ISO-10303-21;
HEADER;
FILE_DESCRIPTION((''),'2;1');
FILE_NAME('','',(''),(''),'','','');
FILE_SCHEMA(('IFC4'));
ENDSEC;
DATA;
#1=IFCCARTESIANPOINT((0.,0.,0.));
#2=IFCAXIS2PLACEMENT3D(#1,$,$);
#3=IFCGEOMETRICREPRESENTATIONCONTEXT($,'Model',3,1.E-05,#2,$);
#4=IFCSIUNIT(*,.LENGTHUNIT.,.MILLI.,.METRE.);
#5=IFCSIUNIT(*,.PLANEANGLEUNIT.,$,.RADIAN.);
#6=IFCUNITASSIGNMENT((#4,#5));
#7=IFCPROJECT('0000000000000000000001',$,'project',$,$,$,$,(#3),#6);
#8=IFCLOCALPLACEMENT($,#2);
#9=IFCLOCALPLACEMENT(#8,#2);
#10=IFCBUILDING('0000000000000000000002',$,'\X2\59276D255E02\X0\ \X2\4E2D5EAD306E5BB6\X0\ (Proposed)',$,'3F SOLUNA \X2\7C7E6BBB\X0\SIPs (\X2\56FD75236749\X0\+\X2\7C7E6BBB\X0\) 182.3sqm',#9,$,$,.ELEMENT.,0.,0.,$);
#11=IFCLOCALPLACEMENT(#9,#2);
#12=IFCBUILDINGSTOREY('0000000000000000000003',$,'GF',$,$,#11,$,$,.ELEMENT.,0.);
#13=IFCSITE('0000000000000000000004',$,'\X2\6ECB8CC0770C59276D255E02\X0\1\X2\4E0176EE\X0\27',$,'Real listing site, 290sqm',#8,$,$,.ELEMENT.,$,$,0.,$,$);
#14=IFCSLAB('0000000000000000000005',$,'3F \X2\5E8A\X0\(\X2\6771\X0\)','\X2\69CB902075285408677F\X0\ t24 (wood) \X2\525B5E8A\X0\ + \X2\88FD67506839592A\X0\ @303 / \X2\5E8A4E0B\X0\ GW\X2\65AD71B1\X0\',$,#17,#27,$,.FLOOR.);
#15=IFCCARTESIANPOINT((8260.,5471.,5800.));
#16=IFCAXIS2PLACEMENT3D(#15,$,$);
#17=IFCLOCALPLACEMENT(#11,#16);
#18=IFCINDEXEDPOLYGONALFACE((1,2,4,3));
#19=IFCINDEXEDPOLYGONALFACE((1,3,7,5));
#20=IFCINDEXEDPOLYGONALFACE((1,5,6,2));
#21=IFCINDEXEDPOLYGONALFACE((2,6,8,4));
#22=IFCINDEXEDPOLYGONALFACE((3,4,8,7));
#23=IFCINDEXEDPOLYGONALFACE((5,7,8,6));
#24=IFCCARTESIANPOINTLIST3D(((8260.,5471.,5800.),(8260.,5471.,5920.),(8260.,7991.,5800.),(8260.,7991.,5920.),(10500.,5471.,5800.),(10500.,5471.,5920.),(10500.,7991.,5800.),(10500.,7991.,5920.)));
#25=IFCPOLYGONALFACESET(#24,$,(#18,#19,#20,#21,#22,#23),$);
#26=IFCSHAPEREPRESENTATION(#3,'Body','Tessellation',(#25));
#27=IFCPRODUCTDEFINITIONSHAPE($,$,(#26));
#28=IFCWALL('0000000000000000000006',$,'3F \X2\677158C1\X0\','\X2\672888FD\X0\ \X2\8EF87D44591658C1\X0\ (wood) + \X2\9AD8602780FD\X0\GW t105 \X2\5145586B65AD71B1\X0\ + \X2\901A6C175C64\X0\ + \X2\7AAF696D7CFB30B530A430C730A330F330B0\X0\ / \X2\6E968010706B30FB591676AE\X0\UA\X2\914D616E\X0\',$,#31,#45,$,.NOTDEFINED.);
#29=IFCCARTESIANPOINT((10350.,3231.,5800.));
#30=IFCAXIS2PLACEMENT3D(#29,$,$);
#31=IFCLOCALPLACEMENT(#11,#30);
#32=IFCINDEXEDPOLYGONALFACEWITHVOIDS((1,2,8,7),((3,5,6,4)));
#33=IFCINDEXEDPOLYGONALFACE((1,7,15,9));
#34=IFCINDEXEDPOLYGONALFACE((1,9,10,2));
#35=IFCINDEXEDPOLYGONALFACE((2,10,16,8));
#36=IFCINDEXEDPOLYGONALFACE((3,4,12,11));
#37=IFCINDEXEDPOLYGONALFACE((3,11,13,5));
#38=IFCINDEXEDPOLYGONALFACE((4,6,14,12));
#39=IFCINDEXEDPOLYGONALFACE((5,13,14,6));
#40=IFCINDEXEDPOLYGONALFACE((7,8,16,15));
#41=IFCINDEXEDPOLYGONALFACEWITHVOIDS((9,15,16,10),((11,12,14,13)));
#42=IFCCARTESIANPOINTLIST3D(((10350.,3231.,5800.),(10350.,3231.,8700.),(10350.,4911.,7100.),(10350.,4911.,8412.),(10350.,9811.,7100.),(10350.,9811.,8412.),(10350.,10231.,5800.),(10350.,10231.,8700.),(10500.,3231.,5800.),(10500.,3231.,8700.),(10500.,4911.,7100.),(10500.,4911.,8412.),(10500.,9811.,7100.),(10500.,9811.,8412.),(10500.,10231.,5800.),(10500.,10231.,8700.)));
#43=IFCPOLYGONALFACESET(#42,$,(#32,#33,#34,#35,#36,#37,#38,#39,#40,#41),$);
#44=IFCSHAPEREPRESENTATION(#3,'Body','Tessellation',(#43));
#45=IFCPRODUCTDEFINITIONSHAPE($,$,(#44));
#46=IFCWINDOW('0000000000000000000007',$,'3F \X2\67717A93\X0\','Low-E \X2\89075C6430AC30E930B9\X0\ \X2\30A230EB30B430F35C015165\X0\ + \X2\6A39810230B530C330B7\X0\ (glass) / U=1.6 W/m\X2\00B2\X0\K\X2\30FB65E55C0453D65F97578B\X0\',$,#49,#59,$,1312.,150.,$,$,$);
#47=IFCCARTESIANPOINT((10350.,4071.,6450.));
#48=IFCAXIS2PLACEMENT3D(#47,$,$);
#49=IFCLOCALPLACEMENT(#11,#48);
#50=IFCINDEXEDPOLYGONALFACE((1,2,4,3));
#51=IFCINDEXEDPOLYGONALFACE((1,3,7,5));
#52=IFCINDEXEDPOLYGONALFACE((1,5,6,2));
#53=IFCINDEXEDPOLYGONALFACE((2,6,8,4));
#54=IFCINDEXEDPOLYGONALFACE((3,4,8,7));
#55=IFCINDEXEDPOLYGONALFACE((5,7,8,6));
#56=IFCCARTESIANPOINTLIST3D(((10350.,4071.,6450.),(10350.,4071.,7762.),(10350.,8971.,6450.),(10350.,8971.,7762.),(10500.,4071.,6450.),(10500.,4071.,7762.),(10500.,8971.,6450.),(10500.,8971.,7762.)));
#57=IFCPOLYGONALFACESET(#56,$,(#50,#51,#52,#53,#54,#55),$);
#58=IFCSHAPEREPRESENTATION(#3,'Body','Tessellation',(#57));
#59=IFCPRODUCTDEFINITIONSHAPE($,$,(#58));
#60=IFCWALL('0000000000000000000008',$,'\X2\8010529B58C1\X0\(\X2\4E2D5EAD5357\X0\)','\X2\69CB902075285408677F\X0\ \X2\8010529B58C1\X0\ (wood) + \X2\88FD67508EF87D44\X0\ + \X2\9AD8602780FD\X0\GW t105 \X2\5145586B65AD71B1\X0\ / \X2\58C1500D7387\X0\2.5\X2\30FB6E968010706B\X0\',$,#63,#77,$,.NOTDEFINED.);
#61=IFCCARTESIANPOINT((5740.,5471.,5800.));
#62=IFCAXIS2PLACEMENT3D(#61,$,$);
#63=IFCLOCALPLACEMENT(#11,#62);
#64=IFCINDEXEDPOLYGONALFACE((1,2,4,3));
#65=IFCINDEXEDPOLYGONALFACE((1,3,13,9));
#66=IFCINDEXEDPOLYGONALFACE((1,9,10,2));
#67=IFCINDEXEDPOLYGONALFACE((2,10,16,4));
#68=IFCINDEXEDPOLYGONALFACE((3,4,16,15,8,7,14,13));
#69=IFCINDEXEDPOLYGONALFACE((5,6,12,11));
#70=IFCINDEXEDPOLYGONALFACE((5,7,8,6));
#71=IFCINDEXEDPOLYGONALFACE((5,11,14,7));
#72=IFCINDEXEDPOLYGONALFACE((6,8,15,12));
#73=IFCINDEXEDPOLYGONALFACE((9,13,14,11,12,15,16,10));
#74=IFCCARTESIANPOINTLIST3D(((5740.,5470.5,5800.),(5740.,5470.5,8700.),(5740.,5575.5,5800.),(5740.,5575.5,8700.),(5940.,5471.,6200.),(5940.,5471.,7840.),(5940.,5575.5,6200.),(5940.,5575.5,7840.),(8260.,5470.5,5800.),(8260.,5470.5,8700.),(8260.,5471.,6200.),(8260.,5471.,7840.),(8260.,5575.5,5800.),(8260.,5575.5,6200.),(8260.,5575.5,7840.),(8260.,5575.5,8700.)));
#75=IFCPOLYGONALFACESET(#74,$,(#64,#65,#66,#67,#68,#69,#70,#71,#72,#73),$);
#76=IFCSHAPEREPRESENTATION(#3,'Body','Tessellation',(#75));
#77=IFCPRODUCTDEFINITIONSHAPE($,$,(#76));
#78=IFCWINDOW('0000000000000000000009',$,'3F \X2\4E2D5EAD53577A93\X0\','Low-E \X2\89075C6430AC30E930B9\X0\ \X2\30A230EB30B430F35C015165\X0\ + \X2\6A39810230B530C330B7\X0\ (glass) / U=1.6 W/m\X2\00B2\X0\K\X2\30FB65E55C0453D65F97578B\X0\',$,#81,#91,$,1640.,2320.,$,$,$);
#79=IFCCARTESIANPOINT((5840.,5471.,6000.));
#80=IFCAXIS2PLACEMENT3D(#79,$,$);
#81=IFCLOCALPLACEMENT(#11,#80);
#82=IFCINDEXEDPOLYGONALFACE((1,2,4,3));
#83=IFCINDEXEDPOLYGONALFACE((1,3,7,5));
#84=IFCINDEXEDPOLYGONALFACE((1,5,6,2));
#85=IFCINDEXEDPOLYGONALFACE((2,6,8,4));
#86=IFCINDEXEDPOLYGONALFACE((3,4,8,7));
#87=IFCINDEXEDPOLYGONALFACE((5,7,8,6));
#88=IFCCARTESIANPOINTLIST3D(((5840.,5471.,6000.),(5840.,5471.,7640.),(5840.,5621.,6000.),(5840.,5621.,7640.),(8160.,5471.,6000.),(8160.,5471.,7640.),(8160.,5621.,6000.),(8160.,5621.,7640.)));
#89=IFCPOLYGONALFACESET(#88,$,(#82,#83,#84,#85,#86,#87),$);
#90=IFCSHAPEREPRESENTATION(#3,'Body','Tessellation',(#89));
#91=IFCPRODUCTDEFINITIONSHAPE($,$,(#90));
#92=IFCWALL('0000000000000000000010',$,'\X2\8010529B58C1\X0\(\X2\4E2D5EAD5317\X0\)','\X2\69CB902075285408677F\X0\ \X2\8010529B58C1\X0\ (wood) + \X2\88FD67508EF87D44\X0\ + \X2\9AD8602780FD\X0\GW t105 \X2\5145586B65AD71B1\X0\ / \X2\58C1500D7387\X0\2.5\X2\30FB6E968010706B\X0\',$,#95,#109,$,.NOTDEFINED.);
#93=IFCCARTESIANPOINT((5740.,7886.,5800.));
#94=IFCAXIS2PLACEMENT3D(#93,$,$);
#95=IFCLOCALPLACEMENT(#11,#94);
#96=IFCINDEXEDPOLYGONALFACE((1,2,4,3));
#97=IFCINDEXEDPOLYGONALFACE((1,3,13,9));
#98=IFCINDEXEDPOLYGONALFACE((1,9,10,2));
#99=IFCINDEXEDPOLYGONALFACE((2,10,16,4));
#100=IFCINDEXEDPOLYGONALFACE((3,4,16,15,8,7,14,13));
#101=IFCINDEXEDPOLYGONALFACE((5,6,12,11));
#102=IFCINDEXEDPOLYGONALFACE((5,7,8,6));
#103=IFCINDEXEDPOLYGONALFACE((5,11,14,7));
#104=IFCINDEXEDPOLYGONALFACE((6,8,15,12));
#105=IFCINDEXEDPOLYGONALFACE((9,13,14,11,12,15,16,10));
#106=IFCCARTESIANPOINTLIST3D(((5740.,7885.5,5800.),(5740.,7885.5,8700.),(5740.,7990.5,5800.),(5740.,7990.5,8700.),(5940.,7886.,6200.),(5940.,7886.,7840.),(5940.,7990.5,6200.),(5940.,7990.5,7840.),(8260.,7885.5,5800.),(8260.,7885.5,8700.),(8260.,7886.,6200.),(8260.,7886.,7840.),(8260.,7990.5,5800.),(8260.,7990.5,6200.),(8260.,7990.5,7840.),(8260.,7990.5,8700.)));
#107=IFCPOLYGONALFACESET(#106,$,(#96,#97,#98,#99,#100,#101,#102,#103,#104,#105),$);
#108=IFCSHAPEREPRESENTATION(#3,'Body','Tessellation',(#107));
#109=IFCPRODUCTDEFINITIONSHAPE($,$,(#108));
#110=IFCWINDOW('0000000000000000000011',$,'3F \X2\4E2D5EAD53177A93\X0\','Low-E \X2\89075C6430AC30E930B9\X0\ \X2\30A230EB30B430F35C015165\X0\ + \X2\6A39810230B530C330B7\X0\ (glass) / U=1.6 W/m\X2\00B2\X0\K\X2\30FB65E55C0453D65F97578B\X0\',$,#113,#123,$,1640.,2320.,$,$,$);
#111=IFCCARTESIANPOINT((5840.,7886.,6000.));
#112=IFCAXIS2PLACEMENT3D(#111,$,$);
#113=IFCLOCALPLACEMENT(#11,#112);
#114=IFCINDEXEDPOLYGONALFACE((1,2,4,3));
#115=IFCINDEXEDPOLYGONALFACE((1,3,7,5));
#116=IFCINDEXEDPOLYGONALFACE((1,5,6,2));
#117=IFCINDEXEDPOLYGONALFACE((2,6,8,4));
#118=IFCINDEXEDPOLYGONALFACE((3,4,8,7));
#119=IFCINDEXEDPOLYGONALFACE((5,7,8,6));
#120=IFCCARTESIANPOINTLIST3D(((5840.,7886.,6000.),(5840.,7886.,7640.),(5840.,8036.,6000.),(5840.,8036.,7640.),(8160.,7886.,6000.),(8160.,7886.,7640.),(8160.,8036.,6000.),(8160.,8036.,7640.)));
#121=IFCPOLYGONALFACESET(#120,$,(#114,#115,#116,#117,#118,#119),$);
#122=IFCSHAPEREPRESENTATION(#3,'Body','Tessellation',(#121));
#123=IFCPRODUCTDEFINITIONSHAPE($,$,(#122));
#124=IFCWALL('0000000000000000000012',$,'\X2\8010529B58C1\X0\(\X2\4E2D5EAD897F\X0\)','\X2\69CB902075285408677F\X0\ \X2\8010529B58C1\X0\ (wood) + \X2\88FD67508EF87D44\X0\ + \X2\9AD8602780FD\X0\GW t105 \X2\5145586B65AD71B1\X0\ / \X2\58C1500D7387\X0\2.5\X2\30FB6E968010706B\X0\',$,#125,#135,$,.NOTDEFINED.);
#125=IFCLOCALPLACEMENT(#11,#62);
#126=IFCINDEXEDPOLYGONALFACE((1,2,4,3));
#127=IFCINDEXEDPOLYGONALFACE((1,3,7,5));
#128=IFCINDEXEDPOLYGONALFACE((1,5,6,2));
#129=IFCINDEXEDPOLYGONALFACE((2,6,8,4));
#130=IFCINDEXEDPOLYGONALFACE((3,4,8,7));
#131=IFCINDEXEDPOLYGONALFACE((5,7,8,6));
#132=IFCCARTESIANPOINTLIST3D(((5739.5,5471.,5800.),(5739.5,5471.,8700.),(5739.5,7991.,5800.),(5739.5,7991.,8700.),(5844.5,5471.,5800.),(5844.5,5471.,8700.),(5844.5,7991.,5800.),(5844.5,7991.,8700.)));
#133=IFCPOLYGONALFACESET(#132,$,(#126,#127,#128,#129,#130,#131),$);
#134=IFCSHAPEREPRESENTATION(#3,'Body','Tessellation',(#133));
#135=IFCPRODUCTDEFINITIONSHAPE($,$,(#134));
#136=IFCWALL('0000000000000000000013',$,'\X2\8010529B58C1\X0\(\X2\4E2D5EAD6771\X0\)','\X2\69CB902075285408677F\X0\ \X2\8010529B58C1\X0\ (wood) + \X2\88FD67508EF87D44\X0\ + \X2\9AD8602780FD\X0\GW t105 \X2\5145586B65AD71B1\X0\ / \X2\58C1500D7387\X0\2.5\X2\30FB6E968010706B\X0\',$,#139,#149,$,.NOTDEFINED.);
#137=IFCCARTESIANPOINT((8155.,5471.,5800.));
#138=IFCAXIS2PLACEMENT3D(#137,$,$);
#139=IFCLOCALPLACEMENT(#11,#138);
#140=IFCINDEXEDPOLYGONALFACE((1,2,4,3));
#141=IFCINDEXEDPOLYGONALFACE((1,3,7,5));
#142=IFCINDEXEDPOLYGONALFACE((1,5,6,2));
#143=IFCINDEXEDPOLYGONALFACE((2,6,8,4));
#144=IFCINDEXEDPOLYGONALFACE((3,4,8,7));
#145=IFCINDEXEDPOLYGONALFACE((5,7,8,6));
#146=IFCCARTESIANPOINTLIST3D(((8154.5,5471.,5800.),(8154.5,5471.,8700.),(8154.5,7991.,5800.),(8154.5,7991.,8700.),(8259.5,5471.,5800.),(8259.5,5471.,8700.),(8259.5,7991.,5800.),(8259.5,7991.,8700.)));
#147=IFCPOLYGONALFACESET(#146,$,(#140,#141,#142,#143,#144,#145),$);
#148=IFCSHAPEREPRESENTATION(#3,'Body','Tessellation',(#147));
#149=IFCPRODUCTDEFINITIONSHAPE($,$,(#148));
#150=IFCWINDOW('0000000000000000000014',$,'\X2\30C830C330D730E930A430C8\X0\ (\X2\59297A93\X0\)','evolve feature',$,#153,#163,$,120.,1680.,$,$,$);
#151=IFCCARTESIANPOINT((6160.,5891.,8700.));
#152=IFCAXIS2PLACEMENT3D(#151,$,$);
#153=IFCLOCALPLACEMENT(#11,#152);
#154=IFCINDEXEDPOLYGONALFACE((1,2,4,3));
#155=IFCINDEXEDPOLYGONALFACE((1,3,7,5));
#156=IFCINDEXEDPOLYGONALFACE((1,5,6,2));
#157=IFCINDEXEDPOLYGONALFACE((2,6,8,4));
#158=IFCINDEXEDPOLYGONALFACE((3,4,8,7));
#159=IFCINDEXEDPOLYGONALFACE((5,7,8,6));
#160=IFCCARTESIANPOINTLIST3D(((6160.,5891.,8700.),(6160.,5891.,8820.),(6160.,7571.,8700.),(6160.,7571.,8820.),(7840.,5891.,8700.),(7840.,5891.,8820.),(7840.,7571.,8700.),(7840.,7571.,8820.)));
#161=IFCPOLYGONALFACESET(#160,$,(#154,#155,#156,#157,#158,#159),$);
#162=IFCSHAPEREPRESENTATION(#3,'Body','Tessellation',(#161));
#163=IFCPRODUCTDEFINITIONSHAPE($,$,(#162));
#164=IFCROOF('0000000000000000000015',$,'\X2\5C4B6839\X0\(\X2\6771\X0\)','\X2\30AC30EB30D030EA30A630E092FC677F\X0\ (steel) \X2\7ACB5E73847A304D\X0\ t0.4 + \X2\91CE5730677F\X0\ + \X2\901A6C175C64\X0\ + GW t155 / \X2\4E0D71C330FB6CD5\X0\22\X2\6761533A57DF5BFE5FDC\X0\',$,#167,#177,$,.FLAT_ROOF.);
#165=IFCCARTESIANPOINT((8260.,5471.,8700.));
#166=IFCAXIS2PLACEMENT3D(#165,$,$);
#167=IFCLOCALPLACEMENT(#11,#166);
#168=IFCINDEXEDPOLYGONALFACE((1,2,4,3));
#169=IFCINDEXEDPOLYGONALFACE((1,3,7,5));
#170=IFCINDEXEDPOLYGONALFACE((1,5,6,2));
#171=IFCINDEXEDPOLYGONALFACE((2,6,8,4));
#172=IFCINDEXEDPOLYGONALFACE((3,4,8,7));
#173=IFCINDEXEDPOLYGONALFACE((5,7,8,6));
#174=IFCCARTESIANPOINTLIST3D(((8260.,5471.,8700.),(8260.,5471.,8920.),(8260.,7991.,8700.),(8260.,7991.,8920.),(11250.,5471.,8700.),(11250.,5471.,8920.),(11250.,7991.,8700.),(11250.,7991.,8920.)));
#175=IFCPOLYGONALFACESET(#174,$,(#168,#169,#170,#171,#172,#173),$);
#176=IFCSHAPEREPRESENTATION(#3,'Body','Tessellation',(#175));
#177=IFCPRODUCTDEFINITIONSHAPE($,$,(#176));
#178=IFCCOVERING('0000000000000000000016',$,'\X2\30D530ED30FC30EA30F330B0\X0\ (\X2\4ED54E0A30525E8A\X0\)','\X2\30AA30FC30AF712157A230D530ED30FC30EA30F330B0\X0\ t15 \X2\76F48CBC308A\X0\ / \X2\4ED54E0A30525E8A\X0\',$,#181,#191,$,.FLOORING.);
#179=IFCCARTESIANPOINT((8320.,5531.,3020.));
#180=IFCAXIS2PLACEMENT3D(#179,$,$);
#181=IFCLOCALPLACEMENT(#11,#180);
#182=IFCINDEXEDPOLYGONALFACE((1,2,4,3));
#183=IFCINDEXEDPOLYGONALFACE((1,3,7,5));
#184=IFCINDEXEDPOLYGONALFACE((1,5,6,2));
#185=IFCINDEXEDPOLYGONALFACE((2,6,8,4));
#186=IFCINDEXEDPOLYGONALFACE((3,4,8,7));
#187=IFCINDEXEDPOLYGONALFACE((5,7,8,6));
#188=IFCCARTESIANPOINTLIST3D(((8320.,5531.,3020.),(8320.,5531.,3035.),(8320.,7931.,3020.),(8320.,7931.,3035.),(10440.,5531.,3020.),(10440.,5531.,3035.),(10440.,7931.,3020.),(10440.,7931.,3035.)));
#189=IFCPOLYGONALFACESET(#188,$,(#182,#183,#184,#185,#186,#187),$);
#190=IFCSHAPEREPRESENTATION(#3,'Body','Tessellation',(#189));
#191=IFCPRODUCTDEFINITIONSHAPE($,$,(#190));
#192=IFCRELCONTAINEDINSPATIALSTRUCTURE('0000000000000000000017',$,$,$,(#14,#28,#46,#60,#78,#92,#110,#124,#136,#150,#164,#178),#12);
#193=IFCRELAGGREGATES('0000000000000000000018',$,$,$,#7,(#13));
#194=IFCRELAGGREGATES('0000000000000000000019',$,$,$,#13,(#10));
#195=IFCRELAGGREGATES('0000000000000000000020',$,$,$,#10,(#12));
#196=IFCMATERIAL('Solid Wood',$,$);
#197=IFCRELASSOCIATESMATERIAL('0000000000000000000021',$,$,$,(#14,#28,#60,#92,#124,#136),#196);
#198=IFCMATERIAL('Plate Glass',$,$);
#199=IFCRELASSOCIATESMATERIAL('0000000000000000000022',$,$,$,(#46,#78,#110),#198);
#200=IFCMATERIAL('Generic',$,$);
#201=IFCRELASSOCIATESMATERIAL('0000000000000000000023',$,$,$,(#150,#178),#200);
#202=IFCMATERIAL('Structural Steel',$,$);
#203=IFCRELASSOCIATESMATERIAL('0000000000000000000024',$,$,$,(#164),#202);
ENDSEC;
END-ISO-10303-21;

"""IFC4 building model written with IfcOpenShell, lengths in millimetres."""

from ifc_helpers import new_model, si_unit, frame, frame_2d, origin, place, context, project, spatial, rectangle, extrude, material, element, fill, save


model = new_model("IFC4")

# Units and contexts
model_context = context("Model", 3, precision=1e-05, world=origin())
ifc_project = project(units=[si_unit("LENGTHUNIT", "METRE", prefix="MILLI"), si_unit("PLANEANGLEUNIT", "RADIAN")], contexts=[model_context])

# Site, building, storey
site_placement = place(None, origin())
site = spatial("IfcSite", under=ifc_project, at=site_placement, Name="滋賀県大津市1丁目27", ObjectType="Real listing site, 290sqm", CompositionType="ELEMENT", RefElevation=0.0)
building_placement = place(site_placement, origin())
building = spatial("IfcBuilding", under=site, at=building_placement, Name="大津市 中庭の家 (Proposed)", ObjectType="3F SOLUNA 籾殻SIPs (国産杉+籾殻) 182.3sqm", CompositionType="ELEMENT", ElevationOfRefHeight=0.0, ElevationOfTerrain=0.0)
storey_placement = place(building_placement, origin())
storey = spatial("IfcBuildingStorey", under=building, at=storey_placement, Name="GF", CompositionType="ELEMENT", Elevation=0.0)

# Slab
ifc_material_1 = material(Name="Solid Wood")
slab_placement = place(storey_placement, frame((8260.0, 5471.0, 5800.0)))
element("IfcSlab", 1, at=slab_placement, inside=storey, material=ifc_material_1, Name="3F 床(東)", Description="構造用合板 t24 (wood) 剛床 + 製材根太 @303 / 床下 GW断熱", PredefinedType="FLOOR", context=model_context, shape_type="SweptSolid", body=[
    extrude(rectangle(XDim=2240.0, YDim=2520.0, at=frame_2d((1120.0, 1260.0))), frame((8260.0, 5471.0, 5800.0)), (0.0, 0.0, 1.0), 120.0),
])

# Walls, openings, windows
wall_1_placement = place(storey_placement, frame((10350.0, 3231.0, 5800.0)))
wall_1 = element("IfcWall", 2, at=wall_1_placement, inside=storey, material=ifc_material_1, Name="3F 東壁", Description="木製 軸組外壁 (wood) + 高性能GW t105 充填断熱 + 通気層 + 窯業系サイディング / 準耐火・外皮UA配慮", PredefinedType="NOTDEFINED", context=model_context, shape_type="SweptSolid", body=[
    extrude(rectangle(XDim=150.0, YDim=7000.0, at=frame_2d((75.0, 3500.0))), frame((10350.0, 3231.0, 5800.0)), (0.0, 0.0, 1.0), 2900.0),
])
opening_1_placement = place(storey_placement, frame((10350.0, 4071.0, 6450.0)))
opening_1 = element("IfcOpeningElement", 3, at=opening_1_placement, cuts=wall_1, PredefinedType="NOTDEFINED", context=model_context, shape_type="SweptSolid", body=[
    extrude(rectangle(XDim=150.0, YDim=4900.0, at=frame_2d((75.0, 2450.0))), frame((10350.0, 4071.0, 6450.0)), (0.0, 0.0, 1.0), 1312.0),
])
ifc_material_2 = material(Name="Plate Glass")
window_1_placement = place(storey_placement, frame((10350.0, 4071.0, 6450.0)))
window_1 = element("IfcWindow", 4, at=window_1_placement, inside=storey, material=ifc_material_2, Name="3F 東窓", Description="Low-E 複層ガラス アルゴン封入 + 樹脂サッシ (glass) / U=1.6 W/m²K・日射取得型", OverallHeight=1312.0, OverallWidth=150.0, context=model_context, shape_type="SweptSolid", body=[
    extrude(rectangle(XDim=150.0, YDim=4900.0, at=frame_2d((75.0, 2450.0))), frame((10350.0, 4071.0, 6450.0)), (0.0, 0.0, 1.0), 1312.0),
])
fill(opening_1, window_1)
wall_2_placement = place(storey_placement, frame((5740.0, 5471.0, 5800.0)))
wall_2 = element("IfcWall", 5, at=wall_2_placement, inside=storey, material=ifc_material_1, Name="耐力壁(中庭南)", Description="構造用合板 耐力壁 (wood) + 製材軸組 + 高性能GW t105 充填断熱 / 壁倍率2.5・準耐火", PredefinedType="NOTDEFINED", context=model_context, shape_type="SweptSolid", body=[
    extrude(rectangle(XDim=2520.0, YDim=105.0, at=frame_2d((1260.0, 52.0))), frame((5740.0, 5471.0, 5800.0)), (0.0, 0.0, 1.0), 2900.0),
])
opening_2_placement = place(storey_placement, frame((5840.0, 5471.0, 6000.0)))
opening_2 = element("IfcOpeningElement", 6, at=opening_2_placement, cuts=wall_2, PredefinedType="NOTDEFINED", context=model_context, shape_type="SweptSolid", body=[
    extrude(rectangle(XDim=2320.0, YDim=150.0, at=frame_2d((1160.0, 75.0))), frame((5840.0, 5471.0, 6000.0)), (0.0, 0.0, 1.0), 1640.0),
])
window_2_placement = place(storey_placement, frame((5840.0, 5471.0, 6000.0)))
window_2 = element("IfcWindow", 7, at=window_2_placement, inside=storey, material=ifc_material_2, Name="3F 中庭南窓", Description="Low-E 複層ガラス アルゴン封入 + 樹脂サッシ (glass) / U=1.6 W/m²K・日射取得型", OverallHeight=1640.0, OverallWidth=2320.0, context=model_context, shape_type="SweptSolid", body=[
    extrude(rectangle(XDim=2320.0, YDim=150.0, at=frame_2d((1160.0, 75.0))), frame((5840.0, 5471.0, 6000.0)), (0.0, 0.0, 1.0), 1640.0),
])
fill(opening_2, window_2)
wall_3_placement = place(storey_placement, frame((5740.0, 7886.0, 5800.0)))
wall_3 = element("IfcWall", 8, at=wall_3_placement, inside=storey, material=ifc_material_1, Name="耐力壁(中庭北)", Description="構造用合板 耐力壁 (wood) + 製材軸組 + 高性能GW t105 充填断熱 / 壁倍率2.5・準耐火", PredefinedType="NOTDEFINED", context=model_context, shape_type="SweptSolid", body=[
    extrude(rectangle(XDim=2520.0, YDim=105.0, at=frame_2d((1260.0, 52.0))), frame((5740.0, 7886.0, 5800.0)), (0.0, 0.0, 1.0), 2900.0),
])
opening_3_placement = place(storey_placement, frame((5840.0, 7886.0, 6000.0)))
opening_3 = element("IfcOpeningElement", 9, at=opening_3_placement, cuts=wall_3, PredefinedType="NOTDEFINED", context=model_context, shape_type="SweptSolid", body=[
    extrude(rectangle(XDim=2320.0, YDim=150.0, at=frame_2d((1160.0, 75.0))), frame((5840.0, 7886.0, 6000.0)), (0.0, 0.0, 1.0), 1640.0),
])
window_3_placement = place(storey_placement, frame((5840.0, 7886.0, 6000.0)))
window_3 = element("IfcWindow", 10, at=window_3_placement, inside=storey, material=ifc_material_2, Name="3F 中庭北窓", Description="Low-E 複層ガラス アルゴン封入 + 樹脂サッシ (glass) / U=1.6 W/m²K・日射取得型", OverallHeight=1640.0, OverallWidth=2320.0, context=model_context, shape_type="SweptSolid", body=[
    extrude(rectangle(XDim=2320.0, YDim=150.0, at=frame_2d((1160.0, 75.0))), frame((5840.0, 7886.0, 6000.0)), (0.0, 0.0, 1.0), 1640.0),
])
fill(opening_3, window_3)

# Walls
wall_4_placement = place(storey_placement, frame((5740.0, 5471.0, 5800.0)))
element("IfcWall", 11, at=wall_4_placement, inside=storey, material=ifc_material_1, Name="耐力壁(中庭西)", Description="構造用合板 耐力壁 (wood) + 製材軸組 + 高性能GW t105 充填断熱 / 壁倍率2.5・準耐火", PredefinedType="NOTDEFINED", context=model_context, shape_type="SweptSolid", body=[
    extrude(rectangle(XDim=105.0, YDim=2520.0, at=frame_2d((52.0, 1260.0))), frame((5740.0, 5471.0, 5800.0)), (0.0, 0.0, 1.0), 2900.0),
])
wall_5_placement = place(storey_placement, frame((8155.0, 5471.0, 5800.0)))
element("IfcWall", 12, at=wall_5_placement, inside=storey, material=ifc_material_1, Name="耐力壁(中庭東)", Description="構造用合板 耐力壁 (wood) + 製材軸組 + 高性能GW t105 充填断熱 / 壁倍率2.5・準耐火", PredefinedType="NOTDEFINED", context=model_context, shape_type="SweptSolid", body=[
    extrude(rectangle(XDim=105.0, YDim=2520.0, at=frame_2d((52.0, 1260.0))), frame((8155.0, 5471.0, 5800.0)), (0.0, 0.0, 1.0), 2900.0),
])

# Window
ifc_material_3 = material(Name="Generic")
window_4_placement = place(storey_placement, frame((6160.0, 5891.0, 8700.0)))
element("IfcWindow", 13, at=window_4_placement, inside=storey, material=ifc_material_3, Name="トップライト (天窓)", Description="evolve feature", OverallHeight=120.0, OverallWidth=1680.0, context=model_context, shape_type="SweptSolid", body=[
    extrude(rectangle(XDim=1680.0, YDim=1680.0, at=frame_2d((840.0, 840.0))), frame((6160.0, 5891.0, 8700.0)), (0.0, 0.0, 1.0), 120.0),
])

# Roof
ifc_material_4 = material(Name="Structural Steel")
for number, where, name in (
    (14, (8260.0, 5471.0, 8700.0), "屋根(東)"),
):
    element("IfcRoof", number, at=place(storey_placement, frame(where)), inside=storey, material=ifc_material_4, Name=name, Description="ガルバリウム鋼板 (steel) 立平葺き t0.4 + 野地板 + 通気層 + GW t155 / 不燃・法22条区域対応", PredefinedType="FLAT_ROOF", context=model_context, shape_type="SweptSolid", body=[
        extrude(rectangle(XDim=2990.0, YDim=2520.0, at=frame_2d((1495.0, 1260.0))), frame((8260.0, 5471.0, 8700.0)), (0.0, 0.0, 1.0), 220.0),
    ])

# Covering
covering_1_placement = place(storey_placement, frame((8320.0, 5531.0, 3020.0)))
element("IfcCovering", 15, at=covering_1_placement, inside=storey, material=ifc_material_3, Name="フローリング (仕上げ床)", Description="オーク無垢フローリング t15 直貼り / 仕上げ床", PredefinedType="FLOORING", context=model_context, shape_type="SweptSolid", body=[
    extrude(rectangle(XDim=2120.0, YDim=2400.0, at=frame_2d((1060.0, 1200.0))), frame((8320.0, 5531.0, 3020.0)), (0.0, 0.0, 1.0), 15.0),
])

save(model, "model.ifc")
